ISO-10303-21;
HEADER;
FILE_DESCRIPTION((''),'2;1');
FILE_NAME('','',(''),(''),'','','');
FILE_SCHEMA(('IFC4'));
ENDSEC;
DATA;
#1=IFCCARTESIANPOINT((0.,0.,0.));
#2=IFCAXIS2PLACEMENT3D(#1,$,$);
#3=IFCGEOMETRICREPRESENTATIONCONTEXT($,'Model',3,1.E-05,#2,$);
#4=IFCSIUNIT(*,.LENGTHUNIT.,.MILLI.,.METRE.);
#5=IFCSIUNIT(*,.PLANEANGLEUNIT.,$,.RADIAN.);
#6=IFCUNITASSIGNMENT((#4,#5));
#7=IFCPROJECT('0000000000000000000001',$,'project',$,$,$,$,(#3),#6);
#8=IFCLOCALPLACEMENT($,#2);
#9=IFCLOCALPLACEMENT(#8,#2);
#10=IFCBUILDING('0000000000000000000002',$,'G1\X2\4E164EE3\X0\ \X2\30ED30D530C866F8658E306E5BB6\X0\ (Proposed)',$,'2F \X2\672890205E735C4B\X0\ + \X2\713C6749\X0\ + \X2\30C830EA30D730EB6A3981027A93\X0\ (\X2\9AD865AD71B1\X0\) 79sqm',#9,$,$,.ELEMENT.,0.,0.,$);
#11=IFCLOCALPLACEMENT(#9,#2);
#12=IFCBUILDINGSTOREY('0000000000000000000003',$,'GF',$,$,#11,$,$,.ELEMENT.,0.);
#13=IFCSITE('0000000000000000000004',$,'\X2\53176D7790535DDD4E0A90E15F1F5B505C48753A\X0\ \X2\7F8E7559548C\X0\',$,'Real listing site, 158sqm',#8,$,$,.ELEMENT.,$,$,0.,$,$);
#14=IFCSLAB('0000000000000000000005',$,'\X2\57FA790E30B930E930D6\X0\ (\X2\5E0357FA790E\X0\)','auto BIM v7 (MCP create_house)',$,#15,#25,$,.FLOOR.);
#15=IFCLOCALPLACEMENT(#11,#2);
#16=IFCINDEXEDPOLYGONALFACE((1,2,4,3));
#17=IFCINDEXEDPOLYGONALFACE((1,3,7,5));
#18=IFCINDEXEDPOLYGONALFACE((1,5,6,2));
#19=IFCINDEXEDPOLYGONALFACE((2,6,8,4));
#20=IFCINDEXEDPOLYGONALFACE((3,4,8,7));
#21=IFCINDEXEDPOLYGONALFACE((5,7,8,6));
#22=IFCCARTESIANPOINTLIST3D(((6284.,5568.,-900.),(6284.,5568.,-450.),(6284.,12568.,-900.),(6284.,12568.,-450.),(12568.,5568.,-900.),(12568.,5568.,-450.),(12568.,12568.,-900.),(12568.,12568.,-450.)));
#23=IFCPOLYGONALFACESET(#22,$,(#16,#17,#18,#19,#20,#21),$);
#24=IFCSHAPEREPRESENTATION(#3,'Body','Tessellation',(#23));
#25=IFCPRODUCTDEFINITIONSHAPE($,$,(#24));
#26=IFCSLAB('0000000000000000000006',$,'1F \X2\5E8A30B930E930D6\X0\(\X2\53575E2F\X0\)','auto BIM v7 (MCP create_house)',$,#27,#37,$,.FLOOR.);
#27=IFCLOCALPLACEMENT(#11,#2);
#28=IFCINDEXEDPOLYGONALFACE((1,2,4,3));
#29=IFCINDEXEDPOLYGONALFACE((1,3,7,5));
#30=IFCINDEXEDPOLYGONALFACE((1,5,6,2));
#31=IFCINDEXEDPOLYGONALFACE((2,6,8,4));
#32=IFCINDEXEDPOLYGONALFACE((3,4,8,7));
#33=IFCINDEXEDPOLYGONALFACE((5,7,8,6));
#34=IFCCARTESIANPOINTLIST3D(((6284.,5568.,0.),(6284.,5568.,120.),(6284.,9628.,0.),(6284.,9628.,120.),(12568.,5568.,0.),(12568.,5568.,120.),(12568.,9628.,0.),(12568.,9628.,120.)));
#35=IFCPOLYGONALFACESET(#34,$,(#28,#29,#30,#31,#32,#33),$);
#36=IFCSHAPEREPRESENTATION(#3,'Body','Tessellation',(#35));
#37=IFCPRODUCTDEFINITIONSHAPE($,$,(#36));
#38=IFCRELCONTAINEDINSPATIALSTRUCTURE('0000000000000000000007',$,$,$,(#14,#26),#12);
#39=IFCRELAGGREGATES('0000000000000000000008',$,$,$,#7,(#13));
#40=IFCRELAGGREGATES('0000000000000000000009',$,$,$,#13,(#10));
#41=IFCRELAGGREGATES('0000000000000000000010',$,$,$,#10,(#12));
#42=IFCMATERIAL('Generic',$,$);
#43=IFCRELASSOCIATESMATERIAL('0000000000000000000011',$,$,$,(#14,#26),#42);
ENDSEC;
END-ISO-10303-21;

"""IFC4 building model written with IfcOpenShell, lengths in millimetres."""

from ifc_helpers import new_model, si_unit, frame, frame_2d, origin, place, context, project, spatial, rectangle, extrude, material, element, save


model = new_model("IFC4")

# Units and contexts
model_context = context("Model", 3, precision=1e-05, world=origin())
ifc_project = project(units=[si_unit("LENGTHUNIT", "METRE", prefix="MILLI"), si_unit("PLANEANGLEUNIT", "RADIAN")], contexts=[model_context])

# Site, building, storey
site_placement = place(None, origin())
site = spatial("IfcSite", under=ifc_project, at=site_placement, Name="北海道川上郡弟子屈町 美留和", ObjectType="Real listing site, 158sqm", CompositionType="ELEMENT", RefElevation=0.0)
building_placement = place(site_placement, origin())
building = spatial("IfcBuilding", under=site, at=building_placement, Name="G1世代 ロフト書斎の家 (Proposed)", ObjectType="2F 木造平屋 + 焼杉 + トリプル樹脂窓 (高断熱) 79sqm", CompositionType="ELEMENT", ElevationOfRefHeight=0.0, ElevationOfTerrain=0.0)
storey_placement = place(building_placement, origin())
storey = spatial("IfcBuildingStorey", under=building, at=storey_placement, Name="GF", CompositionType="ELEMENT", Elevation=0.0)

# Slabs
ifc_material = material(Name="Generic")
slab_1_placement = place(storey_placement, frame((3142.0, 2784.0, -450.0)))
element("IfcSlab", 1, at=slab_1_placement, inside=storey, material=ifc_material, Name="基礎スラブ (布基礎)", Description="auto BIM v7 (MCP create_house)", PredefinedType="FLOOR", context=model_context, shape_type="SweptSolid", body=[
    extrude(rectangle(XDim=6284.0, YDim=7000.0, at=frame_2d((3142.0, 3500.0))), frame((3142.0, 2784.0, -450.0)), (0.0, 0.0, 1.0), 450.0),
])
slab_2_placement = place(storey_placement, frame((3142.0, 2784.0, 0.0)))
element("IfcSlab", 2, at=slab_2_placement, inside=storey, material=ifc_material, Name="1F 床スラブ(南帯)", Description="auto BIM v7 (MCP create_house)", PredefinedType="FLOOR", context=model_context, shape_type="SweptSolid", body=[
    extrude(rectangle(XDim=6284.0, YDim=4060.0, at=frame_2d((3142.0, 2030.0))), frame((3142.0, 2784.0, 0.0)), (0.0, 0.0, 1.0), 120.0),
])

save(model, "model.ifc")
